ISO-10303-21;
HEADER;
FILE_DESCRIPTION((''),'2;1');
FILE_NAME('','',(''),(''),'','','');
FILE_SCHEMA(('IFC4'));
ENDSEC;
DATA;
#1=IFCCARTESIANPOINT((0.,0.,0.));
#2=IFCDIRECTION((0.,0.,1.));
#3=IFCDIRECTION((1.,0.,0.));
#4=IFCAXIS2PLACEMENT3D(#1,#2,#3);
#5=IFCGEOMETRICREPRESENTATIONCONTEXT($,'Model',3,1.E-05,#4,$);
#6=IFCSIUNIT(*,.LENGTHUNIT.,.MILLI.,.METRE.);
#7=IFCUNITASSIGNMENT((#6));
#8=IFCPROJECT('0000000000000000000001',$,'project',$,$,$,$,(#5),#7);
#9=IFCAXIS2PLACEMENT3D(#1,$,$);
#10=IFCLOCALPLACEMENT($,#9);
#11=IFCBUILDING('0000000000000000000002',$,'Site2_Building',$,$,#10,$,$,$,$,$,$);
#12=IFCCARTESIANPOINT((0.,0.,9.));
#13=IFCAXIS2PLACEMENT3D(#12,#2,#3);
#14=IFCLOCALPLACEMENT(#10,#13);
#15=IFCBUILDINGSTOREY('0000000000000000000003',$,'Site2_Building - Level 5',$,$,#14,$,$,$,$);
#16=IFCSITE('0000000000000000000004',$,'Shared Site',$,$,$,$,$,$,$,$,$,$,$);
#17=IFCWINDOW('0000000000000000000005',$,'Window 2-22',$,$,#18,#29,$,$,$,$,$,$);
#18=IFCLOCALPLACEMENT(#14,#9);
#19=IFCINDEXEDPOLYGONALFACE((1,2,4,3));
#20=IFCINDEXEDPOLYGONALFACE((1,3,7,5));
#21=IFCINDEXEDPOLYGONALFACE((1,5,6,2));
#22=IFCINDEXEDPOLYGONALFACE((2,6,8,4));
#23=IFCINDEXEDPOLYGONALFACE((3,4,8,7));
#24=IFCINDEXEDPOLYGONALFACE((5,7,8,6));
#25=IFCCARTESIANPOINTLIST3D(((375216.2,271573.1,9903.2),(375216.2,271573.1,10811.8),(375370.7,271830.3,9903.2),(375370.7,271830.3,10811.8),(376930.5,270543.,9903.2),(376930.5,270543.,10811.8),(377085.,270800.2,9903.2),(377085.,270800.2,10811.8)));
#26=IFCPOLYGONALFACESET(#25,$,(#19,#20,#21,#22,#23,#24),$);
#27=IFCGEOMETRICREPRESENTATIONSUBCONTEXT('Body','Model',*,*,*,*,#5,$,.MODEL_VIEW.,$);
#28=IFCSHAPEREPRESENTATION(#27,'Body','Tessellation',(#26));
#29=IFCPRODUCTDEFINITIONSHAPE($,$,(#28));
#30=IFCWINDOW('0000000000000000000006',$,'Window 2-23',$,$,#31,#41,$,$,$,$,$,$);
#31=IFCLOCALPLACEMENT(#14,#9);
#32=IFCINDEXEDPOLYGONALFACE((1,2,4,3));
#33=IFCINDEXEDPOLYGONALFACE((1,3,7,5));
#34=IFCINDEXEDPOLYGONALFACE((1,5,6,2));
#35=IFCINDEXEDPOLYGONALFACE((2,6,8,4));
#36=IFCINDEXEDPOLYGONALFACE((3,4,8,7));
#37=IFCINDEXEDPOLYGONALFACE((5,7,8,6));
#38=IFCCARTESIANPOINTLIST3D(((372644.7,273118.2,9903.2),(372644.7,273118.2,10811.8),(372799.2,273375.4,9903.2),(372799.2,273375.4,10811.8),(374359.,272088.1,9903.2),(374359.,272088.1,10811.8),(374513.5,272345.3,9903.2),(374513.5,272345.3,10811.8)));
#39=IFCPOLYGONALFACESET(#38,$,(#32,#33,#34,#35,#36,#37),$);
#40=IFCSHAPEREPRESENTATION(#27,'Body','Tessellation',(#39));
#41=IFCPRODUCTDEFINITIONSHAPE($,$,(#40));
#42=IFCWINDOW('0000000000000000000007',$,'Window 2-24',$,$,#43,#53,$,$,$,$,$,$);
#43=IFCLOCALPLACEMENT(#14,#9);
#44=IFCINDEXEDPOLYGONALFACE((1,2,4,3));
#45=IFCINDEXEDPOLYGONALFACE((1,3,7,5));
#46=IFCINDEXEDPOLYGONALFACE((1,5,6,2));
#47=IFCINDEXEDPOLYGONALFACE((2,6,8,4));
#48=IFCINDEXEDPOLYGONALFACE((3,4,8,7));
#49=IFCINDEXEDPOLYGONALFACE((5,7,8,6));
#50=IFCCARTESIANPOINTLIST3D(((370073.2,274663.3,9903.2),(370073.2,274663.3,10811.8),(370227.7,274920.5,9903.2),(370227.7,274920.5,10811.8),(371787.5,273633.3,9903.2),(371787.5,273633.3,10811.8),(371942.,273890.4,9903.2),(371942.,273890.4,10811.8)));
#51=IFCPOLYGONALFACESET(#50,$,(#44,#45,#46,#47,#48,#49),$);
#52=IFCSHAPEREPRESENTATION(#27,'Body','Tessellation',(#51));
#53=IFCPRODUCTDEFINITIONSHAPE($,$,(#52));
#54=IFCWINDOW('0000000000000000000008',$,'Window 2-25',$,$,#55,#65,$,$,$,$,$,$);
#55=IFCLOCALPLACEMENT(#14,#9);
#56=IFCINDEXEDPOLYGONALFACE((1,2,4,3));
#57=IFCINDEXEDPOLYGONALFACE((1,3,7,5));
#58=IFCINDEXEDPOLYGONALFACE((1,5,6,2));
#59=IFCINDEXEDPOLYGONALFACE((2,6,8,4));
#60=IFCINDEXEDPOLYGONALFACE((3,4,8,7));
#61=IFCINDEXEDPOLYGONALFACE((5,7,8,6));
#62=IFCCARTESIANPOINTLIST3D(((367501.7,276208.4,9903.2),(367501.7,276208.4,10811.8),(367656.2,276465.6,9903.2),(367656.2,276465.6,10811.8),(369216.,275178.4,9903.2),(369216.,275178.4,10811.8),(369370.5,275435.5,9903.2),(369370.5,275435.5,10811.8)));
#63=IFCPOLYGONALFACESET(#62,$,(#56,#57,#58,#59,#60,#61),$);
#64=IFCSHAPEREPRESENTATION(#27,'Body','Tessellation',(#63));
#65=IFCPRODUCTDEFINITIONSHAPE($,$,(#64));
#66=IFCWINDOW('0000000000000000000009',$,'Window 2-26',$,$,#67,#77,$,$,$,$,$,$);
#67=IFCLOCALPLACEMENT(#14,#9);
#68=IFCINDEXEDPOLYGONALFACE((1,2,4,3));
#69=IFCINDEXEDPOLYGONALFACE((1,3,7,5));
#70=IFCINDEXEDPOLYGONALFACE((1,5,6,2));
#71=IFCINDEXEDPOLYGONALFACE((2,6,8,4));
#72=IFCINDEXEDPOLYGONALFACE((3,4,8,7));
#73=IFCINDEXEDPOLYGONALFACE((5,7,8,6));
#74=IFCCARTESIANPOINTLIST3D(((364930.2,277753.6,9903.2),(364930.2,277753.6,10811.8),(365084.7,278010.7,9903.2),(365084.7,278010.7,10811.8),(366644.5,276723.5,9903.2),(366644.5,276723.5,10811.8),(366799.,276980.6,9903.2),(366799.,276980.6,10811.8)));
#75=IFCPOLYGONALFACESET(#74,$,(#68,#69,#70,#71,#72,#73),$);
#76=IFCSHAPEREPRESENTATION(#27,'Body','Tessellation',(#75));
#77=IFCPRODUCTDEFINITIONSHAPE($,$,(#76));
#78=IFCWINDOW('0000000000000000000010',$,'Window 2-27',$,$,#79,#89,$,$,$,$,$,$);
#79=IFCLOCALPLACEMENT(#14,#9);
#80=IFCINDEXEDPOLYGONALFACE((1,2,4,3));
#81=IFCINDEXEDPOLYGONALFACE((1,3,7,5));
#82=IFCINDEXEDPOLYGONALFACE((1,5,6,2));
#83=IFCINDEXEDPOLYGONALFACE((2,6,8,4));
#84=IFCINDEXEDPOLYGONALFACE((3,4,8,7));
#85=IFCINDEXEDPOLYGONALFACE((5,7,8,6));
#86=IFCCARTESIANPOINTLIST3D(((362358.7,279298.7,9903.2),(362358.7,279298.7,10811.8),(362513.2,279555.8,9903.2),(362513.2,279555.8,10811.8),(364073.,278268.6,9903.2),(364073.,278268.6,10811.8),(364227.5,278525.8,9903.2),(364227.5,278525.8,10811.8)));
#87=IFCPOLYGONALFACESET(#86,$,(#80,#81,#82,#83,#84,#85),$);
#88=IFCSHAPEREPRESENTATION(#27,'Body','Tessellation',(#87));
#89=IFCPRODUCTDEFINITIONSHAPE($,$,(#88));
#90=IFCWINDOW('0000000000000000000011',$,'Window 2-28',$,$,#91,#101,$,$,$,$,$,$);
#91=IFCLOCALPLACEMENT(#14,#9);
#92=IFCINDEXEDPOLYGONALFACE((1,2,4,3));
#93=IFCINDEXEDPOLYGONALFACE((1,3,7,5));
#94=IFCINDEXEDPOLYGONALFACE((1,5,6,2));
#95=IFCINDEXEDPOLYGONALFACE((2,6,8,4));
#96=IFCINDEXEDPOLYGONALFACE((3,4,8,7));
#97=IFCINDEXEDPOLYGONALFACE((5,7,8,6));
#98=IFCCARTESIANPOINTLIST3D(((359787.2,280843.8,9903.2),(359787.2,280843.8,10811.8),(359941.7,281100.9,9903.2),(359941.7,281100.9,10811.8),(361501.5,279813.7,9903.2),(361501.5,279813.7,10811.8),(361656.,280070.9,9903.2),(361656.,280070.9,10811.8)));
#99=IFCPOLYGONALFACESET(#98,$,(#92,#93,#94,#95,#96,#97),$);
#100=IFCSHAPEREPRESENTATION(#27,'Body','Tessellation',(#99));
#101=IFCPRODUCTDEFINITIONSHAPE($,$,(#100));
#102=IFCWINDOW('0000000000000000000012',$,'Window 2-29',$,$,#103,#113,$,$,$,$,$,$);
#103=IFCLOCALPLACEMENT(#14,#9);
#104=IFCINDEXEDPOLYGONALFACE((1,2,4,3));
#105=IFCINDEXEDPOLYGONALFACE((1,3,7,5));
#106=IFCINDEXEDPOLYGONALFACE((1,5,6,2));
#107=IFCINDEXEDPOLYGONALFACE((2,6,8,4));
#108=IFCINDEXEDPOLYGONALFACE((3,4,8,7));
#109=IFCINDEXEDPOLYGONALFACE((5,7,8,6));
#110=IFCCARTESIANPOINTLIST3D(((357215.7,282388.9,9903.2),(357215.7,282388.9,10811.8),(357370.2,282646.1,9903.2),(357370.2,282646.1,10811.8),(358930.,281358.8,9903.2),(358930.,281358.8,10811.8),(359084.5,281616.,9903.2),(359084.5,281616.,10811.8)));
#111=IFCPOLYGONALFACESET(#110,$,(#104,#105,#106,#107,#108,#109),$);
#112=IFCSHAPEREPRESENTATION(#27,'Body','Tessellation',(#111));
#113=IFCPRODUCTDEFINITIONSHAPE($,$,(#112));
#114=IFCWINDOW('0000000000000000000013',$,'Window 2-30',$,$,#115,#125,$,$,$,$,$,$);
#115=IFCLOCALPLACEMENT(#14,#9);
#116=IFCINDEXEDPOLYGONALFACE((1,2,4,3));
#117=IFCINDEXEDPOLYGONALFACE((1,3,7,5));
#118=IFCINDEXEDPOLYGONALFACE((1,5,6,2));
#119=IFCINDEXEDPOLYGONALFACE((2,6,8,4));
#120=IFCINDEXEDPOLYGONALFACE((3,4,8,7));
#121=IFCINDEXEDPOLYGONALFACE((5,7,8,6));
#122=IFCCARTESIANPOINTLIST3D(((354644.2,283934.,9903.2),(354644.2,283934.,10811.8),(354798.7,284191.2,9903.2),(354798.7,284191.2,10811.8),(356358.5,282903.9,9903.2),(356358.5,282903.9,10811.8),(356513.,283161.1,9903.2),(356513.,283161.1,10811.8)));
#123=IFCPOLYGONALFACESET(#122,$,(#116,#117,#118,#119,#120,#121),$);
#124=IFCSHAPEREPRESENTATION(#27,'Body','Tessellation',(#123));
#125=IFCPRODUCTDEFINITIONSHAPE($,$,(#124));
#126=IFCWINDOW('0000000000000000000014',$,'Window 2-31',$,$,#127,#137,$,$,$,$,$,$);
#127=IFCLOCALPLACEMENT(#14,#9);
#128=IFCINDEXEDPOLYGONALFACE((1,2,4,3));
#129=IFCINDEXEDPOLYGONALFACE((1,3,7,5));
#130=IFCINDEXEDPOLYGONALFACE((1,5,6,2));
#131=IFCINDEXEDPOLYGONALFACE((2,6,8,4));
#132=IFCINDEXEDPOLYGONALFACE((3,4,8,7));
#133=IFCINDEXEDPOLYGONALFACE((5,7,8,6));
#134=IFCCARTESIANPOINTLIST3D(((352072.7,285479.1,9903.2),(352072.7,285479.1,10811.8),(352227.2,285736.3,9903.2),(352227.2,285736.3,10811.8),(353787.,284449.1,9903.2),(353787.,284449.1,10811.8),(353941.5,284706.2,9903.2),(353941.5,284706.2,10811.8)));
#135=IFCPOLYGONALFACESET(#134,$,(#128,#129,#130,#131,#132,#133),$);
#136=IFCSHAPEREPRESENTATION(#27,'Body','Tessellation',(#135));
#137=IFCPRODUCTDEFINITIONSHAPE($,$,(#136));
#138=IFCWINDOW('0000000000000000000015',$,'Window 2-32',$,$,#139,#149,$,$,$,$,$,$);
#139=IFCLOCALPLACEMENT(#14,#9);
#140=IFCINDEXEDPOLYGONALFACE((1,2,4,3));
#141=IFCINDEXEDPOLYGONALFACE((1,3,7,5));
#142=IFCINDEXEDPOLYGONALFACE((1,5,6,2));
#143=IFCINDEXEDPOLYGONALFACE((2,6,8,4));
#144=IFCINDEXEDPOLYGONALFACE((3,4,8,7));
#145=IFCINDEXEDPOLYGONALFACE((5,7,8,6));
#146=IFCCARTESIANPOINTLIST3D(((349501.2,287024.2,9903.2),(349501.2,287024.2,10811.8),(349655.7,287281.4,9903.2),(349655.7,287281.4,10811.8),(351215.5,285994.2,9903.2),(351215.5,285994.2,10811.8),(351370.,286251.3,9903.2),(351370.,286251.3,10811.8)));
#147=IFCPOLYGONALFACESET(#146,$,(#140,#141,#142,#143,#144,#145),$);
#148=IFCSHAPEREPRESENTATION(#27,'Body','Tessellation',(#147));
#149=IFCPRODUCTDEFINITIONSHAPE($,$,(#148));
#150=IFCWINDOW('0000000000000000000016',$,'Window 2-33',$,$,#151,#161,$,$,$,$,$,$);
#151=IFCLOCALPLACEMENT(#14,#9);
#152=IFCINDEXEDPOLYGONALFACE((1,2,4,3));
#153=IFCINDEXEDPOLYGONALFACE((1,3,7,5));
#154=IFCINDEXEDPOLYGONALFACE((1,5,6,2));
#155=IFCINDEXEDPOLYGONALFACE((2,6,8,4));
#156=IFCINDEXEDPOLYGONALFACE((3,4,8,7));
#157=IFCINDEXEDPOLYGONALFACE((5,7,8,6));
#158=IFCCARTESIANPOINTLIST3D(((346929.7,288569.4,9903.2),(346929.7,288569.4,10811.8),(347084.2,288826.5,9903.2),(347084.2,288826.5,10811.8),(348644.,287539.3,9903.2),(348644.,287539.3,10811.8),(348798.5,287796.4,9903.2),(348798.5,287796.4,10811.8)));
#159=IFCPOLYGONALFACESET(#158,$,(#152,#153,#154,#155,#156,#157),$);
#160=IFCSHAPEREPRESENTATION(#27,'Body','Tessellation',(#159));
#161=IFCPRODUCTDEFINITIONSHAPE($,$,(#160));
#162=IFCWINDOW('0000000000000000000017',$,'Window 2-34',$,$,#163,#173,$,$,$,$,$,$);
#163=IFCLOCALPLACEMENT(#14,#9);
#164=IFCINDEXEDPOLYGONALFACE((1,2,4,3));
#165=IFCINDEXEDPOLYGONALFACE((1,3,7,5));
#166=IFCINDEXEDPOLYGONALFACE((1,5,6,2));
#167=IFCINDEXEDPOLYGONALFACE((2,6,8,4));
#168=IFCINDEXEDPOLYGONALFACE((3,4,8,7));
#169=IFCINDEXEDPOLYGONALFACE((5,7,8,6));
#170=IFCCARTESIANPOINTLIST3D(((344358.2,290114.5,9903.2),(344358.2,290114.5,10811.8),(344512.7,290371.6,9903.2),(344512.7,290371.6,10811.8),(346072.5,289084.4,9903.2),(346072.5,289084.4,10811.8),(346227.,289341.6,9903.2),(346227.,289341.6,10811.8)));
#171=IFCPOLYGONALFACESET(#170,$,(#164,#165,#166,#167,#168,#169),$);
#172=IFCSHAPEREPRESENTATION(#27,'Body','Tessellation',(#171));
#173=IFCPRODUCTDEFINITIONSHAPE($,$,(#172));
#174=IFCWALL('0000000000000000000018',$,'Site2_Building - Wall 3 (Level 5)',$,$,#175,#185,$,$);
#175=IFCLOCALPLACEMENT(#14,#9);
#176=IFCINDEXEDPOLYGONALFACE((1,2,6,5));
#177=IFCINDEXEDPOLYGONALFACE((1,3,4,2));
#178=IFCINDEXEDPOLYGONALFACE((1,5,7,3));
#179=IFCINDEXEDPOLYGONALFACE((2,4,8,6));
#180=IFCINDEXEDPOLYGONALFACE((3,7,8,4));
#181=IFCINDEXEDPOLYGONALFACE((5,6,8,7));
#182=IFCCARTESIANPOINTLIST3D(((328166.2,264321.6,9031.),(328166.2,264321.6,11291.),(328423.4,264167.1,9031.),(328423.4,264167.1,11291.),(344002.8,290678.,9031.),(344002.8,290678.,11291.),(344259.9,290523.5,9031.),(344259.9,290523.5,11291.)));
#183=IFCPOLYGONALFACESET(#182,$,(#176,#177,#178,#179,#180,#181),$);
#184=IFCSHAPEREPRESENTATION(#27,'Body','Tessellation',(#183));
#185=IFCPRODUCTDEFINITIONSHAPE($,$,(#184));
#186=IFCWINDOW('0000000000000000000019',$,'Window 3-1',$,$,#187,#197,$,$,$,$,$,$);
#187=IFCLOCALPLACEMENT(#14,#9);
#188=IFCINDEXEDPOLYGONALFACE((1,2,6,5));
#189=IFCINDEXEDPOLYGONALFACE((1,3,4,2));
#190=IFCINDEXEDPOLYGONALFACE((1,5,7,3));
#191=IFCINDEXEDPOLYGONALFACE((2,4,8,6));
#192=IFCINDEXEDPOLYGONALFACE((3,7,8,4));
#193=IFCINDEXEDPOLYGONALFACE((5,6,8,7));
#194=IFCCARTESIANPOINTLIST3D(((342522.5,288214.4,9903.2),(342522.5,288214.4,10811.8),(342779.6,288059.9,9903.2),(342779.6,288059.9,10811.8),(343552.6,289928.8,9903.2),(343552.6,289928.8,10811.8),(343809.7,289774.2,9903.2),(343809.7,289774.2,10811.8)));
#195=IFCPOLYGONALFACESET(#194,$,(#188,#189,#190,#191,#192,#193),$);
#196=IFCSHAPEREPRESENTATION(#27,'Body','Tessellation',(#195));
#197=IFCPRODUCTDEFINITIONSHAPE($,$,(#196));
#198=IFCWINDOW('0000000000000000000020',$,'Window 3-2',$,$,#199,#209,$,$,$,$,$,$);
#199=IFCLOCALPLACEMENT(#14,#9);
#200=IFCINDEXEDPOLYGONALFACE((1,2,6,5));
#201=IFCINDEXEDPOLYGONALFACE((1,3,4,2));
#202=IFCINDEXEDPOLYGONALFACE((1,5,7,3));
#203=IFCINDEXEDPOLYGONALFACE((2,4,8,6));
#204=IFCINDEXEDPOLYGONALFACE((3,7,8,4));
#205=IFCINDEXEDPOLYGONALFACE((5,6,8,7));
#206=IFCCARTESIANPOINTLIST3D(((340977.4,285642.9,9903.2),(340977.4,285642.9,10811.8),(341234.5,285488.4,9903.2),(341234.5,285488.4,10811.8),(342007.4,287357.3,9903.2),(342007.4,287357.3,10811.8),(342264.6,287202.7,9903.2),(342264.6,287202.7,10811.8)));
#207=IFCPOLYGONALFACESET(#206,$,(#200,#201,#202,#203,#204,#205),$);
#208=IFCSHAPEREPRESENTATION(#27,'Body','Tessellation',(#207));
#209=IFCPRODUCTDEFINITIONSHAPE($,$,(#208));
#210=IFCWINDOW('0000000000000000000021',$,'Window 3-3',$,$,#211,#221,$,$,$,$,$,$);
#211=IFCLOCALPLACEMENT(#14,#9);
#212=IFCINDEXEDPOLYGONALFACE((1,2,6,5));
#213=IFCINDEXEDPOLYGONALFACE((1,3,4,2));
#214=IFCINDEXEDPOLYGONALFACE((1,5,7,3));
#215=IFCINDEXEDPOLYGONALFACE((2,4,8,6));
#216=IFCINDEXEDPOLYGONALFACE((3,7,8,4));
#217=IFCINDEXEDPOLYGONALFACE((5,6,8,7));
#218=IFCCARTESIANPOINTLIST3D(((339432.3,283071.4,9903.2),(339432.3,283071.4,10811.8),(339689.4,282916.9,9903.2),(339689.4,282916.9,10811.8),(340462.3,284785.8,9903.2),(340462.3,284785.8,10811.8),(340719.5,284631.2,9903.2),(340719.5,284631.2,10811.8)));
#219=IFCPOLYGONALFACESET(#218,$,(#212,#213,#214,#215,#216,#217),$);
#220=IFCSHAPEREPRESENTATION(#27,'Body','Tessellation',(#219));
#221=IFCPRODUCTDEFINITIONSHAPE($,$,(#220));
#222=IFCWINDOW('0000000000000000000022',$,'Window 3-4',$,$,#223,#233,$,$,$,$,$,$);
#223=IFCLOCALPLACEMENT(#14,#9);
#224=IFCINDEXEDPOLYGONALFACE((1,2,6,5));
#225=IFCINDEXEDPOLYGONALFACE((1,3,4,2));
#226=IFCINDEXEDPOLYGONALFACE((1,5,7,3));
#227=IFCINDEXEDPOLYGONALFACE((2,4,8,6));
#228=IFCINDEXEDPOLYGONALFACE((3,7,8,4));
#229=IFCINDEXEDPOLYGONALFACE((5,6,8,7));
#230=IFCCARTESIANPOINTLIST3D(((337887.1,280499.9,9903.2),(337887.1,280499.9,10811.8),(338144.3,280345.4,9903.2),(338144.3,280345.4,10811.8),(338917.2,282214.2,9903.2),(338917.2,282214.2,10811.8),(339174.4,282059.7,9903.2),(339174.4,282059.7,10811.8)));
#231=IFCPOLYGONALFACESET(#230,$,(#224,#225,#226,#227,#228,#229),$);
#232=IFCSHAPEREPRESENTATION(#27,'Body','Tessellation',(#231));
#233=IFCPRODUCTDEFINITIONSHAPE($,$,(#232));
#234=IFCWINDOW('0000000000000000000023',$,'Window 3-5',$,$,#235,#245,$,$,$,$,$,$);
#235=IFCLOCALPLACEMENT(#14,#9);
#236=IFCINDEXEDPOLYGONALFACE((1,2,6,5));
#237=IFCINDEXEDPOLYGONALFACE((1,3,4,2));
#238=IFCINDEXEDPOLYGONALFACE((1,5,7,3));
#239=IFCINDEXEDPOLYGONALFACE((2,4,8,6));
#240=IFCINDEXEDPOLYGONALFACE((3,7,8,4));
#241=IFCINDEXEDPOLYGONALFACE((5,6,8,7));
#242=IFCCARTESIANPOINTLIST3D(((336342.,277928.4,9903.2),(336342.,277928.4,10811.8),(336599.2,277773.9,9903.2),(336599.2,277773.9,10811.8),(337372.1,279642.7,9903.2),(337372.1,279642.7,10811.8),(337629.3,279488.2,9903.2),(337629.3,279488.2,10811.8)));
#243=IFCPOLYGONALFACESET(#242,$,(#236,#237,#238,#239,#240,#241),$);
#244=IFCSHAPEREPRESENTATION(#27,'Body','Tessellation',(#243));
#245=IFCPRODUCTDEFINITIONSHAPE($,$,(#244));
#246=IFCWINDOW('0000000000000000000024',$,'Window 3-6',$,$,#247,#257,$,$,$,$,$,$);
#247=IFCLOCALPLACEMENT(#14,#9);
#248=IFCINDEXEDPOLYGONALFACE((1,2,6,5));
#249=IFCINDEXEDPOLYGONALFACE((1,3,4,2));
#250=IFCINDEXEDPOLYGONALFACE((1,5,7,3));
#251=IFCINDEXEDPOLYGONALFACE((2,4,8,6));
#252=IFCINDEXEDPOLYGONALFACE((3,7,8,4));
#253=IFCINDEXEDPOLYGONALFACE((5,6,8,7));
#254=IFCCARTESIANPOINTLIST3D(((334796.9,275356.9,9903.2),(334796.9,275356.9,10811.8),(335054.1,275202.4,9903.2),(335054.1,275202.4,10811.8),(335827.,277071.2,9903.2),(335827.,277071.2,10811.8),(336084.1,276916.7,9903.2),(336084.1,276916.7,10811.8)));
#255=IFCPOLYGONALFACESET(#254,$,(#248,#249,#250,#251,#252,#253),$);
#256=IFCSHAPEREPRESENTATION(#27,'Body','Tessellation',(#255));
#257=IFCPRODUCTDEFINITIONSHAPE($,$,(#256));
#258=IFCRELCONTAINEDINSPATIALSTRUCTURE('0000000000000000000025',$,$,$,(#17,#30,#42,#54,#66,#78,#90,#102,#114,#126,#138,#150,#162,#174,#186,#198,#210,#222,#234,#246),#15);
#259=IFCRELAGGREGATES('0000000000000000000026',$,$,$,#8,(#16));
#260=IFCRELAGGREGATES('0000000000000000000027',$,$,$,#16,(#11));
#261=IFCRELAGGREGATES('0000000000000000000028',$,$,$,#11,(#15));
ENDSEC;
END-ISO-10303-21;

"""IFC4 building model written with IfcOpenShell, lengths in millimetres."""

from ifc_helpers import new_model, si_unit, frame, origin, origin_with_axes, place, context, subcontext, project, spatial, indexed_curve, outline, extrude, element, save


model = new_model("IFC4")

# Units and contexts
model_context = context("Model", 3, precision=1e-05, world=origin_with_axes())
body_context = subcontext(model_context, "Body", "Model", "MODEL_VIEW")
ifc_project = project(units=[si_unit("LENGTHUNIT", "METRE", prefix="MILLI")], contexts=[model_context])

# Site, building, storey
site = spatial("IfcSite", under=ifc_project, Name="Shared Site")
building_placement = place(None, origin())
building = spatial("IfcBuilding", under=site, at=building_placement, Name="Site2_Building")
storey_placement = place(building_placement, frame((0.0, 0.0, 9.0), z_axis=(0.0, 0.0, 1.0), x_axis=(1.0, 0.0, 0.0)))
storey = spatial("IfcBuildingStorey", under=building, at=storey_placement, Name="Site2_Building - Level 5")

# Windows
for number, where, z_axis, x_axis, name in (
    (1, (377085.0, 270800.2, 9903.2), (0.0, 0.0, 1.0), (-0.857167, 0.515038, 0.0), "Window 2-22"),
    (2, (374513.5, 272345.3, 9903.2), (0.0, 0.0, 1.0), (-0.857167, 0.515038, 0.0), "Window 2-23"),
    (3, (371942.0, 273890.4, 9903.2), (0.0, 0.0, 1.0), (-0.857167, 0.515038, 0.0), "Window 2-24"),
    (4, (369370.5, 275435.5, 9903.2), (0.0, 0.0, 1.0), (-0.857167, 0.515038, 0.0), "Window 2-25"),
    (5, (366799.0, 276980.6, 9903.2), (0.0, 0.0, 1.0), (-0.857167, 0.515038, 0.0), "Window 2-26"),
    (6, (364227.5, 278525.8, 9903.2), (0.0, 0.0, 1.0), (-0.857167, 0.515038, 0.0), "Window 2-27"),
    (7, (361656.0, 280070.9, 9903.2), (0.0, 0.0, 1.0), (-0.857167, 0.515038, 0.0), "Window 2-28"),
    (8, (359084.5, 281616.0, 9903.2), (0.0, 0.0, 1.0), (-0.857167, 0.515038, 0.0), "Window 2-29"),
    (9, (356513.0, 283161.1, 9903.2), (0.0, 0.0, 1.0), (-0.857167, 0.515038, 0.0), "Window 2-30"),
    (10, (353941.5, 284706.2, 9903.2), (0.0, 0.0, 1.0), (-0.857167, 0.515038, 0.0), "Window 2-31"),
    (11, (351370.0, 286251.3, 9903.2), (0.0, 0.0, 1.0), (-0.857167, 0.515038, 0.0), "Window 2-32"),
    (12, (348798.5, 287796.4, 9903.2), (0.0, 0.0, 1.0), (-0.857167, 0.515038, 0.0), "Window 2-33"),
    (13, (346227.0, 289341.6, 9903.2), (0.0, 0.0, 1.0), (-0.857167, 0.515038, 0.0), "Window 2-34"),
):
    element("IfcWindow", number, at=place(storey_placement, frame(where, z_axis=z_axis, x_axis=x_axis)), inside=storey, Name=name, context=body_context, shape_type="SweptSolid", body=[
        extrude(outline(indexed_curve([(0.0, 0.0), (0.0, 300.0), (2000.0, 300.0), (2000.0, 0.0), (0.0, 0.0)], self_intersect=False)), origin_with_axes(), (0.0, 0.0, 1.0), 908.6),
    ])

# Wall
wall_placement = place(storey_placement, frame((344002.8, 290678.0, 9031.0), z_axis=(0.0, 0.0, 1.0), x_axis=(-0.515038, -0.857167, 0.0)))
element("IfcWall", 14, at=wall_placement, inside=storey, Name="Site2_Building - Wall 3 (Level 5)", context=body_context, shape_type="SweptSolid", body=[
    extrude(outline(indexed_curve([(0.0, 0.0), (0.0, 300.0), (30748.2, 300.0), (30748.2, 0.0), (0.0, 0.0)], self_intersect=False)), origin_with_axes(), (0.0, 0.0, 1.0), 2260.0),
])

# Windows
for number, where, z_axis, x_axis, name in (
    (15, (343552.6, 289928.8, 9903.2), (0.0, 0.0, 1.0), (-0.515038, -0.857167, 0.0), "Window 3-1"),
    (16, (342007.4, 287357.3, 9903.2), (0.0, 0.0, 1.0), (-0.515038, -0.857167, 0.0), "Window 3-2"),
    (17, (340462.3, 284785.8, 9903.2), (0.0, 0.0, 1.0), (-0.515038, -0.857167, 0.0), "Window 3-3"),
    (18, (338917.2, 282214.2, 9903.2), (0.0, 0.0, 1.0), (-0.515038, -0.857167, 0.0), "Window 3-4"),
    (19, (337372.1, 279642.7, 9903.2), (0.0, 0.0, 1.0), (-0.515038, -0.857167, 0.0), "Window 3-5"),
    (20, (335827.0, 277071.2, 9903.2), (0.0, 0.0, 1.0), (-0.515038, -0.857167, 0.0), "Window 3-6"),
):
    element("IfcWindow", number, at=place(storey_placement, frame(where, z_axis=z_axis, x_axis=x_axis)), inside=storey, Name=name, context=body_context, shape_type="SweptSolid", body=[
        extrude(outline(indexed_curve([(0.0, 0.0), (0.0, 300.0), (2000.0, 300.0), (2000.0, 0.0), (0.0, 0.0)], self_intersect=False)), origin_with_axes(), (0.0, 0.0, 1.0), 908.6),
    ])

save(model, "model.ifc")
